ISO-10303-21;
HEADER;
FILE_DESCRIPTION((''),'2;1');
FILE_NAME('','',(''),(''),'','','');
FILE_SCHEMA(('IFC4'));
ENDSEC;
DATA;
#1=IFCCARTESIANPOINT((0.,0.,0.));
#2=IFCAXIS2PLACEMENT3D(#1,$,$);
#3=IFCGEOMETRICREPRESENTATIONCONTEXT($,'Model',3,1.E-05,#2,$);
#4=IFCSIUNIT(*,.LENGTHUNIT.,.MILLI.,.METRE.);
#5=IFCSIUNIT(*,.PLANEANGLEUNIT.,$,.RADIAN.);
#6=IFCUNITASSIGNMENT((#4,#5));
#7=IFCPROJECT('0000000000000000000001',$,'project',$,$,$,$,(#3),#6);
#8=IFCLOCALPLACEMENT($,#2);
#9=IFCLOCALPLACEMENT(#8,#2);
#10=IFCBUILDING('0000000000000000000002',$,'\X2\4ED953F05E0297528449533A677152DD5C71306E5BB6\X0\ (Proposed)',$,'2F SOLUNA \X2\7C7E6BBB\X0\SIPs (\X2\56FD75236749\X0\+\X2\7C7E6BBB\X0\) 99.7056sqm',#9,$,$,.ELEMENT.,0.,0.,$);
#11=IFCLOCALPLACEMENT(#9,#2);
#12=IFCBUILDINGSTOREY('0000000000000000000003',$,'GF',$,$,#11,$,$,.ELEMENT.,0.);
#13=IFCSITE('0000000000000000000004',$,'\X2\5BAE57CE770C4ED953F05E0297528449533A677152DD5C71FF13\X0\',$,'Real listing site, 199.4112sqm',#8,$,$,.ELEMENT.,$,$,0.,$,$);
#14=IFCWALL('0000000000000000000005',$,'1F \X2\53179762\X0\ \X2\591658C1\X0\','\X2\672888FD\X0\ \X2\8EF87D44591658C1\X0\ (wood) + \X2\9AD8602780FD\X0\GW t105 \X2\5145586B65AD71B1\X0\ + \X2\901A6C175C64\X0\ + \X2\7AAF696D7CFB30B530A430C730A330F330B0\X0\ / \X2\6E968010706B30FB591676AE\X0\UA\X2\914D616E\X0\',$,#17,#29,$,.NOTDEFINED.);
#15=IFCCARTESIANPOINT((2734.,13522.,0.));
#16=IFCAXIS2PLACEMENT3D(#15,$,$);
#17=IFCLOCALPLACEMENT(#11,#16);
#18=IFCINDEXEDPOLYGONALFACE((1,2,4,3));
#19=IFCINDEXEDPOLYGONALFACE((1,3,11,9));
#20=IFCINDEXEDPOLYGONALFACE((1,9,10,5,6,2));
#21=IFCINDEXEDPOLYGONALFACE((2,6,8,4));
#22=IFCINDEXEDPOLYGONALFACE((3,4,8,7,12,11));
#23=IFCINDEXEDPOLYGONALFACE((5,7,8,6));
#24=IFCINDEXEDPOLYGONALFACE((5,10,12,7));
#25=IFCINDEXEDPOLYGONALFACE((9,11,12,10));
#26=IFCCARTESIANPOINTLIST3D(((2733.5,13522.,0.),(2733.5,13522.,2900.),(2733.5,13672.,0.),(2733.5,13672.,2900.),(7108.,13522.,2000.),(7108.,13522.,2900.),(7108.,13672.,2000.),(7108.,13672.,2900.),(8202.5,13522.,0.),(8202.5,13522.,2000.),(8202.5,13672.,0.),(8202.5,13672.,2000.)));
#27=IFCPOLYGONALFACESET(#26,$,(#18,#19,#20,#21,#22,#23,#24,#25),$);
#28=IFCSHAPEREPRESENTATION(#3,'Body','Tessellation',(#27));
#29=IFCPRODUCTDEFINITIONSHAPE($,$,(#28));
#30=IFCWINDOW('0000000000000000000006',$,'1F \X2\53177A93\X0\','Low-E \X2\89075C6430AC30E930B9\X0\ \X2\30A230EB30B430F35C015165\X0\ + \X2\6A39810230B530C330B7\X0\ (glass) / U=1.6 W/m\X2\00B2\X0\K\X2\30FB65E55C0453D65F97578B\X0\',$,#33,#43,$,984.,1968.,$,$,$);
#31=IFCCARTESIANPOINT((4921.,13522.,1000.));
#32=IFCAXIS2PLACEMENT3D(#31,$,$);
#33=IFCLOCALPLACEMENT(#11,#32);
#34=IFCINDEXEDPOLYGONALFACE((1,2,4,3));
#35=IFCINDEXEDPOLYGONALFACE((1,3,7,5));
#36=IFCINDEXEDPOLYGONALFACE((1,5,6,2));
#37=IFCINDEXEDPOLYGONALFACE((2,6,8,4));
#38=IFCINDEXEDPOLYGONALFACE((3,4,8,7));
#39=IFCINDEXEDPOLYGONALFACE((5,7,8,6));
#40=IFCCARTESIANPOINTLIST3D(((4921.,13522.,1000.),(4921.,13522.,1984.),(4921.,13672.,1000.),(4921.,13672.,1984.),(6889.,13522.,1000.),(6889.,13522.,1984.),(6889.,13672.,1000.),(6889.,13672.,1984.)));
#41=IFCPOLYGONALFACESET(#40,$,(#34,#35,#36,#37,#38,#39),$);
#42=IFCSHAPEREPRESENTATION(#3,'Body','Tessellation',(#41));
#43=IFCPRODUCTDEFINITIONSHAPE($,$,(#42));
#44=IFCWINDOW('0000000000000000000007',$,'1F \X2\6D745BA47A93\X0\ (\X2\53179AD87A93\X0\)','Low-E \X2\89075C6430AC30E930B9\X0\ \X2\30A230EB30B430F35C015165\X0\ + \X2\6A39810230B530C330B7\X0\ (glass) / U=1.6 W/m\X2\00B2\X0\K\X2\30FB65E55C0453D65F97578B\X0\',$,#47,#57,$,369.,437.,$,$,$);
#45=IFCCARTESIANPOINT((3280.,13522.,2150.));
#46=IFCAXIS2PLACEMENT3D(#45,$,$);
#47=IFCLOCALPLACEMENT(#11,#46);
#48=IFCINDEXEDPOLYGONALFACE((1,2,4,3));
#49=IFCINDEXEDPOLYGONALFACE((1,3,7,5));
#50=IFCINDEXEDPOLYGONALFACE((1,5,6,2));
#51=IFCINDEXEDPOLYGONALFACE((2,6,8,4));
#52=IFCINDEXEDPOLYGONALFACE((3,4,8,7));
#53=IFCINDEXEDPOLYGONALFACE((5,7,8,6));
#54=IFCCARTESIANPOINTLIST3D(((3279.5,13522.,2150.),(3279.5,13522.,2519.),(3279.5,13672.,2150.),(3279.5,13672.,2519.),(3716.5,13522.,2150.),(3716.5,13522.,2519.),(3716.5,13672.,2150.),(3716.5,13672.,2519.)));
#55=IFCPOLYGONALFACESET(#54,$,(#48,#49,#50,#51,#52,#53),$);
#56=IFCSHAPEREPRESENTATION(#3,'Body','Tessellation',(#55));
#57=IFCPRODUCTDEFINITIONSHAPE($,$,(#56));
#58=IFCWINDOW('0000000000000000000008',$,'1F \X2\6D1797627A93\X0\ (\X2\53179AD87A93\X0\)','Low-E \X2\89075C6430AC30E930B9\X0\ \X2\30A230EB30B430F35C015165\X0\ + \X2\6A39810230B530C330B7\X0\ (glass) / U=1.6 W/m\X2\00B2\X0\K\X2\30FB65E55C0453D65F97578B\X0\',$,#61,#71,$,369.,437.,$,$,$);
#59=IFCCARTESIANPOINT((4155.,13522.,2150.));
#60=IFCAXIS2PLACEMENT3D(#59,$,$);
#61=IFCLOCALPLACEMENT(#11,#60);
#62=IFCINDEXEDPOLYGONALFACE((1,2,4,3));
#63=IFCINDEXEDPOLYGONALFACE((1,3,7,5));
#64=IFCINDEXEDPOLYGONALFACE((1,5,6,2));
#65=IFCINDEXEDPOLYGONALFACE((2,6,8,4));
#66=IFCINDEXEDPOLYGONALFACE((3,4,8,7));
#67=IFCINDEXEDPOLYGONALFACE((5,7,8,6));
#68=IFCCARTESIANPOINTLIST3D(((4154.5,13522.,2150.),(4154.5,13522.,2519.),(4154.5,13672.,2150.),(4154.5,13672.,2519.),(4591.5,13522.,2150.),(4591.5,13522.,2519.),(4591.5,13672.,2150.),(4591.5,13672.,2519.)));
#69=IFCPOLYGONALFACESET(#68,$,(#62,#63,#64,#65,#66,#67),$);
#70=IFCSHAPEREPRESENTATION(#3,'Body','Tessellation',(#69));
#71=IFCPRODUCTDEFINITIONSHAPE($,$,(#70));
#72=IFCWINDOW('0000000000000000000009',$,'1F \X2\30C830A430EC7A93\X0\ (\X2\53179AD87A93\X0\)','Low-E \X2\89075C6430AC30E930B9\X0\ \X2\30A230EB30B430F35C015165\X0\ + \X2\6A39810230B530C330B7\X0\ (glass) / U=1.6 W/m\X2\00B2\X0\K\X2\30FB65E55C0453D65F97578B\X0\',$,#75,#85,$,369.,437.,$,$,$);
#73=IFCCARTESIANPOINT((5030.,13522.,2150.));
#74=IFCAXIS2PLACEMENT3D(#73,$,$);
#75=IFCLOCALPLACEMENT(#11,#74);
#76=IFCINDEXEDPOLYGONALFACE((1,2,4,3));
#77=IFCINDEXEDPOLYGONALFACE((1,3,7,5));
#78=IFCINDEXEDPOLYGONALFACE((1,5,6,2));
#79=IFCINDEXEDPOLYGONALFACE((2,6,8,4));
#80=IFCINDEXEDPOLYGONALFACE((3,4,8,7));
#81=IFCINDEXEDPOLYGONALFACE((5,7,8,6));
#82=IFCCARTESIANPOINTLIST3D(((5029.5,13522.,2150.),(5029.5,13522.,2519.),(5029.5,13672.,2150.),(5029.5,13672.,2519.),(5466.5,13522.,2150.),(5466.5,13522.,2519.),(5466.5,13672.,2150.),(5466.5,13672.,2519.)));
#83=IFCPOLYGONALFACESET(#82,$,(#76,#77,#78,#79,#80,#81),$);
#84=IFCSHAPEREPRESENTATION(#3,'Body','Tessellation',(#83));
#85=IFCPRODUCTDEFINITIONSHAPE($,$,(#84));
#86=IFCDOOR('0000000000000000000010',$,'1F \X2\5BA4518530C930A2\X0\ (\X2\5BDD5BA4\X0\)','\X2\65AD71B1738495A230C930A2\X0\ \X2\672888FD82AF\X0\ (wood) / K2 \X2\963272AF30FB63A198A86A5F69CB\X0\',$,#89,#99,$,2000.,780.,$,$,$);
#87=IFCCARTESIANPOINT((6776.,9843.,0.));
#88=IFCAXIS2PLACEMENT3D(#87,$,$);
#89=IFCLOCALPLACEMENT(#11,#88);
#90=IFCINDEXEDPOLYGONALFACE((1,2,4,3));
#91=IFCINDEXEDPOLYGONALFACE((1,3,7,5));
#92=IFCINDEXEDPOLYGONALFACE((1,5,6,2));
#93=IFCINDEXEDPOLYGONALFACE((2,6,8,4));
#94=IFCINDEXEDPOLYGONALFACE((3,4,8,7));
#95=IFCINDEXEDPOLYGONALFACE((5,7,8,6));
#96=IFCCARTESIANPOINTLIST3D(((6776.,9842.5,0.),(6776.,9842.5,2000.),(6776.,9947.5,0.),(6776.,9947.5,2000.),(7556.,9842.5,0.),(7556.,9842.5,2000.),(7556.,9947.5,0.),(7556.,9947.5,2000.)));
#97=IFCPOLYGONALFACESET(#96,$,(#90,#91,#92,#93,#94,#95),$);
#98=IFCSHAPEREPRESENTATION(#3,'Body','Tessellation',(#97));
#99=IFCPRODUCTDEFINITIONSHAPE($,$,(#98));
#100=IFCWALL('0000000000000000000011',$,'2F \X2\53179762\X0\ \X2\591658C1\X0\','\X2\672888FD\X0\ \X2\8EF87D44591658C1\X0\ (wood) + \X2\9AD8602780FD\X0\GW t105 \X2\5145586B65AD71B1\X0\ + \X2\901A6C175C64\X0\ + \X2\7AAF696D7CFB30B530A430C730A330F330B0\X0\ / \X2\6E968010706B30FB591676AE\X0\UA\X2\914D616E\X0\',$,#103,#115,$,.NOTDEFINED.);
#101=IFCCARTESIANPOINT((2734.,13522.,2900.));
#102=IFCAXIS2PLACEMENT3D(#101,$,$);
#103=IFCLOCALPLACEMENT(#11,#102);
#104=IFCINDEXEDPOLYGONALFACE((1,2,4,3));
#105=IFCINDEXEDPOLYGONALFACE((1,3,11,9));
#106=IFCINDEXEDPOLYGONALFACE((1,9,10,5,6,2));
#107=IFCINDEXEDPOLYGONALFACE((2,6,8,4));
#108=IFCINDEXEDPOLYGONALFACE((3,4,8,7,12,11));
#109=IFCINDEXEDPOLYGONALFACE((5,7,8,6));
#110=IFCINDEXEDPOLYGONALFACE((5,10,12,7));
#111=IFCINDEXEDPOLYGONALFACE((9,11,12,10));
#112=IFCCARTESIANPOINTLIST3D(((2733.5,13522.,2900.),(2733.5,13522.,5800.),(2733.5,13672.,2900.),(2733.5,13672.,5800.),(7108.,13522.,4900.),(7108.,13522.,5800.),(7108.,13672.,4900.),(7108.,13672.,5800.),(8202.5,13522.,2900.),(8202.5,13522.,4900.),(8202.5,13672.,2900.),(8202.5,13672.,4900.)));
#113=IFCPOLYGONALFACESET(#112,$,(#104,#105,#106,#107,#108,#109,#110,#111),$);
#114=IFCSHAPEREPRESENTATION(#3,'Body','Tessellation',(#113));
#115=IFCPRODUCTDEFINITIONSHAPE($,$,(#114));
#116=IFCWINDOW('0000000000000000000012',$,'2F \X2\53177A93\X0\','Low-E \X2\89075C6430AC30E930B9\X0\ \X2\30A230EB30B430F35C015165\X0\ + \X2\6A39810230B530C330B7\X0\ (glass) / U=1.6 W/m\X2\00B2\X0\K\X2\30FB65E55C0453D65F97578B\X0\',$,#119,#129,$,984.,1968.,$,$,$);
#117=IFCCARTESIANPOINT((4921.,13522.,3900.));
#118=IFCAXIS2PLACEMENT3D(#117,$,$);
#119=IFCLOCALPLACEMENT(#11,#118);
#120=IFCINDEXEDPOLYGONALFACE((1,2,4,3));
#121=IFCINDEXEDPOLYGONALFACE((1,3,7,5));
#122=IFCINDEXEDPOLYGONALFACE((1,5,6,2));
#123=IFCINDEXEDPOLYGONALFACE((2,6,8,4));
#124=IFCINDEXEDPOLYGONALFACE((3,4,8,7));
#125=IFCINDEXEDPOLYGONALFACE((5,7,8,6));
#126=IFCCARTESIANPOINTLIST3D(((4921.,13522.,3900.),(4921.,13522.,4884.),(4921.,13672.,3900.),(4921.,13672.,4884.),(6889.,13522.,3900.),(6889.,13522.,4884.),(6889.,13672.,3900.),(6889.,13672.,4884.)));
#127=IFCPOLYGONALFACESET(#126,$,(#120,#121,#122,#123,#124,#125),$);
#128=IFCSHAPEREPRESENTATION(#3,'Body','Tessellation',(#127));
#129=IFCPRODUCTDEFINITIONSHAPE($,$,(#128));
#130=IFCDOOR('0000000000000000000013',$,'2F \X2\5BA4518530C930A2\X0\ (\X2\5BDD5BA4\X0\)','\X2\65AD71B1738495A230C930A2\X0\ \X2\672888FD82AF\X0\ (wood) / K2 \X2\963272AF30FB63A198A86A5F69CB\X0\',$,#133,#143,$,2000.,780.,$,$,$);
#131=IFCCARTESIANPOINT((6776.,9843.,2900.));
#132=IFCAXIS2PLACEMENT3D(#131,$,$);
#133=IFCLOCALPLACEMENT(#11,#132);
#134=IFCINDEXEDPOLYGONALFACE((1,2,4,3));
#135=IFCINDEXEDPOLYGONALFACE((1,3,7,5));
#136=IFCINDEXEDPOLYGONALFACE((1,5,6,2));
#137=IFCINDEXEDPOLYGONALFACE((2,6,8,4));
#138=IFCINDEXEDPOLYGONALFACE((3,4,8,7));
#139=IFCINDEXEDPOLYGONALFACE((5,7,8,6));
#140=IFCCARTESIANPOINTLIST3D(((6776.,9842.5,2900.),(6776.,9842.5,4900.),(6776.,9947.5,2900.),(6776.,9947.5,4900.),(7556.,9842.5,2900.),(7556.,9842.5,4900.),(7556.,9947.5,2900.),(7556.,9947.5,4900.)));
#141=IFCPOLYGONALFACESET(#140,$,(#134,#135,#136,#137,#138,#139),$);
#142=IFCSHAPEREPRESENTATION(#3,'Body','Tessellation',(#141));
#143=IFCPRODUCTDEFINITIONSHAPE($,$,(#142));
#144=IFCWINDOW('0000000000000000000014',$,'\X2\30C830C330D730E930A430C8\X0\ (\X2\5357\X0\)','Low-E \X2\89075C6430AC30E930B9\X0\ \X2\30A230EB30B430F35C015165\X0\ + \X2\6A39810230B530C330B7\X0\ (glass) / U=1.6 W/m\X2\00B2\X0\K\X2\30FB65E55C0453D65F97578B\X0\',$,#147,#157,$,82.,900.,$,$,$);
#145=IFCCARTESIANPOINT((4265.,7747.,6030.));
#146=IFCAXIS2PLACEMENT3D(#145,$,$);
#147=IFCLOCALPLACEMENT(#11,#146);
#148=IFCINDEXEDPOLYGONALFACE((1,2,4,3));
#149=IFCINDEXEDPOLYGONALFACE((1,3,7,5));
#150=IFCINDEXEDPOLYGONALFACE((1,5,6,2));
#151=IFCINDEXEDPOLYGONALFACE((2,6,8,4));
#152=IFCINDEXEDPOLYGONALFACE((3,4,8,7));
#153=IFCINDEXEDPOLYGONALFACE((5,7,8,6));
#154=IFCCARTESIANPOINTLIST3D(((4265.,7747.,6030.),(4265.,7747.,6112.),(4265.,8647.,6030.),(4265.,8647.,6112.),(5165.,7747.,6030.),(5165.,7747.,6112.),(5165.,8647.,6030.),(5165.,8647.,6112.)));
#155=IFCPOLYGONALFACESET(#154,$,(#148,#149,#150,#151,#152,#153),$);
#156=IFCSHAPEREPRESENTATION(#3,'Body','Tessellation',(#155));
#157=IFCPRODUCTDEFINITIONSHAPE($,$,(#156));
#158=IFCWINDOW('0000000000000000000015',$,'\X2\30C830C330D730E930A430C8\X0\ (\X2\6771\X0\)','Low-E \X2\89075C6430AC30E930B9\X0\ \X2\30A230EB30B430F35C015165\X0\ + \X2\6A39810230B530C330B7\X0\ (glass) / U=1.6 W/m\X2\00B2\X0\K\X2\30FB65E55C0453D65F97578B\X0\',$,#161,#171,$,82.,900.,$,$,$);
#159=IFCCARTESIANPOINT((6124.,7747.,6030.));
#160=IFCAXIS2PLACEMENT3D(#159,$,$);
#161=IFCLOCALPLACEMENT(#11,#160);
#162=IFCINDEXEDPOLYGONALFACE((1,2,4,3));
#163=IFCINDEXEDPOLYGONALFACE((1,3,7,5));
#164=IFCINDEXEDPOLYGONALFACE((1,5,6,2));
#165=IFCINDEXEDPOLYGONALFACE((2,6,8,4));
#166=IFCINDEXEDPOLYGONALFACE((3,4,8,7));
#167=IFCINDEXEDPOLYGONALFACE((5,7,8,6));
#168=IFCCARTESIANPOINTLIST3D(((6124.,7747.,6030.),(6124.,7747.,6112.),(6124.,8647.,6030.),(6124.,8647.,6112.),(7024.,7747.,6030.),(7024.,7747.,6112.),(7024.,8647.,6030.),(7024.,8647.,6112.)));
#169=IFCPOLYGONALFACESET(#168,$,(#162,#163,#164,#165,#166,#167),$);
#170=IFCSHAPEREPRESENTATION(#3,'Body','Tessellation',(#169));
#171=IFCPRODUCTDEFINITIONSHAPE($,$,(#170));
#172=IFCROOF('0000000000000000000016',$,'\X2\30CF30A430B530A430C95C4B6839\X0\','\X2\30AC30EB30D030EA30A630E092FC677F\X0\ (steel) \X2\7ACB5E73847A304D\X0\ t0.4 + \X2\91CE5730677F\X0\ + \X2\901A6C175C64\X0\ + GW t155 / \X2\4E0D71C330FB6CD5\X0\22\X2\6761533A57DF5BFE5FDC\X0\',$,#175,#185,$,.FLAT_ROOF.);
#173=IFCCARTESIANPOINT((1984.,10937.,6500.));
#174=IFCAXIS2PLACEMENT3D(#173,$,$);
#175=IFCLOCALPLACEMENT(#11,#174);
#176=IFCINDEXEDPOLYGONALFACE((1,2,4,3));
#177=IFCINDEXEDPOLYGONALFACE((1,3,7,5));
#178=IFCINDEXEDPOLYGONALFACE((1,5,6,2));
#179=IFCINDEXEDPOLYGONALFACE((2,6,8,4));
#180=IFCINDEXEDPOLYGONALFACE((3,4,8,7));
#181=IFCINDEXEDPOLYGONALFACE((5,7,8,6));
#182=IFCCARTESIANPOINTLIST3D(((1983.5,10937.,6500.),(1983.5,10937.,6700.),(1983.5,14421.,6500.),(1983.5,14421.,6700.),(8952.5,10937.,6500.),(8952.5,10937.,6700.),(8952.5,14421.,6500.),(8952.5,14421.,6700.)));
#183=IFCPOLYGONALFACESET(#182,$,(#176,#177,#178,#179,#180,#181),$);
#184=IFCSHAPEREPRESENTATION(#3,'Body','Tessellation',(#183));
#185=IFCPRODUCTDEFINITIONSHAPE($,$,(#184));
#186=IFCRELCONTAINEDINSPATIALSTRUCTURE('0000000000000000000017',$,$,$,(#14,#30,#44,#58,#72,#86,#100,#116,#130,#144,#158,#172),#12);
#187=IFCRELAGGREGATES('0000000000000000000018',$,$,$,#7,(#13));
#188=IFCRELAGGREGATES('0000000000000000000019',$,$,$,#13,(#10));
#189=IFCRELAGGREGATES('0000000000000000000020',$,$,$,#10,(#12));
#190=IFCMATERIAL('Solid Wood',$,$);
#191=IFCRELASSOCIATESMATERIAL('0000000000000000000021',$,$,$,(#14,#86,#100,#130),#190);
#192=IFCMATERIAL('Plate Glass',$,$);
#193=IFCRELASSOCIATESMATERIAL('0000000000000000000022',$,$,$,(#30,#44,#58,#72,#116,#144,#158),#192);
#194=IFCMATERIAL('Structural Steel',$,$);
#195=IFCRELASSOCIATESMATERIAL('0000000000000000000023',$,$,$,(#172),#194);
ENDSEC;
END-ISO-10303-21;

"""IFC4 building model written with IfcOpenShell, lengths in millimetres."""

from ifc_helpers import new_model, si_unit, frame, frame_2d, origin, place, context, project, spatial, rectangle, extrude, material, element, fill, save


model = new_model("IFC4")

# Units and contexts
model_context = context("Model", 3, precision=1e-05, world=origin())
ifc_project = project(units=[si_unit("LENGTHUNIT", "METRE", prefix="MILLI"), si_unit("PLANEANGLEUNIT", "RADIAN")], contexts=[model_context])

# Site, building, storey
site_placement = place(None, origin())
site = spatial("IfcSite", under=ifc_project, at=site_placement, Name="宮城県仙台市青葉区東勝山３", ObjectType="Real listing site, 199.4112sqm", CompositionType="ELEMENT", RefElevation=0.0)
building_placement = place(site_placement, origin())
building = spatial("IfcBuilding", under=site, at=building_placement, Name="仙台市青葉区東勝山の家 (Proposed)", ObjectType="2F SOLUNA 籾殻SIPs (国産杉+籾殻) 99.7056sqm", CompositionType="ELEMENT", ElevationOfRefHeight=0.0, ElevationOfTerrain=0.0)
storey_placement = place(building_placement, origin())
storey = spatial("IfcBuildingStorey", under=building, at=storey_placement, Name="GF", CompositionType="ELEMENT", Elevation=0.0)

# Wall, openings, windows
ifc_material_1 = material(Name="Solid Wood")
wall_1_placement = place(storey_placement, frame((2734.0, 13522.0, 0.0)))
wall_1 = element("IfcWall", 1, at=wall_1_placement, inside=storey, material=ifc_material_1, Name="1F 北面 外壁", Description="木製 軸組外壁 (wood) + 高性能GW t105 充填断熱 + 通気層 + 窯業系サイディング / 準耐火・外皮UA配慮", PredefinedType="NOTDEFINED", context=model_context, shape_type="SweptSolid", body=[
    extrude(rectangle(XDim=5469.0, YDim=150.0, at=frame_2d((2734.0, 75.0))), frame((2734.0, 13522.0, 0.0)), (0.0, 0.0, 1.0), 2900.0),
])
opening_1_placement = place(storey_placement, frame((4921.0, 13522.0, 1000.0)))
opening_1 = element("IfcOpeningElement", 2, at=opening_1_placement, cuts=wall_1, PredefinedType="NOTDEFINED", context=model_context, shape_type="SweptSolid", body=[
    extrude(rectangle(XDim=1968.0, YDim=150.0, at=frame_2d((984.0, 75.0))), frame((4921.0, 13522.0, 1000.0)), (0.0, 0.0, 1.0), 984.0),
])
opening_2_placement = place(storey_placement, frame((3280.0, 13522.0, 2150.0)))
opening_2 = element("IfcOpeningElement", 3, at=opening_2_placement, cuts=wall_1, PredefinedType="NOTDEFINED", context=model_context, shape_type="SweptSolid", body=[
    extrude(rectangle(XDim=437.0, YDim=150.0, at=frame_2d((218.0, 75.0))), frame((3280.0, 13522.0, 2150.0)), (0.0, 0.0, 1.0), 369.0),
])
opening_3_placement = place(storey_placement, frame((4155.0, 13522.0, 2150.0)))
opening_3 = element("IfcOpeningElement", 4, at=opening_3_placement, cuts=wall_1, PredefinedType="NOTDEFINED", context=model_context, shape_type="SweptSolid", body=[
    extrude(rectangle(XDim=437.0, YDim=150.0, at=frame_2d((218.0, 75.0))), frame((4155.0, 13522.0, 2150.0)), (0.0, 0.0, 1.0), 369.0),
])
opening_4_placement = place(storey_placement, frame((5030.0, 13522.0, 2150.0)))
opening_4 = element("IfcOpeningElement", 5, at=opening_4_placement, cuts=wall_1, PredefinedType="NOTDEFINED", context=model_context, shape_type="SweptSolid", body=[
    extrude(rectangle(XDim=437.0, YDim=150.0, at=frame_2d((218.0, 75.0))), frame((5030.0, 13522.0, 2150.0)), (0.0, 0.0, 1.0), 369.0),
])
ifc_material_2 = material(Name="Plate Glass")
window_1_placement = place(storey_placement, frame((4921.0, 13522.0, 1000.0)))
window_1 = element("IfcWindow", 6, at=window_1_placement, inside=storey, material=ifc_material_2, Name="1F 北窓", Description="Low-E 複層ガラス アルゴン封入 + 樹脂サッシ (glass) / U=1.6 W/m²K・日射取得型", OverallHeight=984.0, OverallWidth=1968.0, context=model_context, shape_type="SweptSolid", body=[
    extrude(rectangle(XDim=1968.0, YDim=150.0, at=frame_2d((984.0, 75.0))), frame((4921.0, 13522.0, 1000.0)), (0.0, 0.0, 1.0), 984.0),
])
fill(opening_1, window_1)
window_2_placement = place(storey_placement, frame((3280.0, 13522.0, 2150.0)))
window_2 = element("IfcWindow", 7, at=window_2_placement, inside=storey, material=ifc_material_2, Name="1F 浴室窓 (北高窓)", Description="Low-E 複層ガラス アルゴン封入 + 樹脂サッシ (glass) / U=1.6 W/m²K・日射取得型", OverallHeight=369.0, OverallWidth=437.0, context=model_context, shape_type="SweptSolid", body=[
    extrude(rectangle(XDim=437.0, YDim=150.0, at=frame_2d((218.0, 75.0))), frame((3280.0, 13522.0, 2150.0)), (0.0, 0.0, 1.0), 369.0),
])
fill(opening_2, window_2)
window_3_placement = place(storey_placement, frame((4155.0, 13522.0, 2150.0)))
window_3 = element("IfcWindow", 8, at=window_3_placement, inside=storey, material=ifc_material_2, Name="1F 洗面窓 (北高窓)", Description="Low-E 複層ガラス アルゴン封入 + 樹脂サッシ (glass) / U=1.6 W/m²K・日射取得型", OverallHeight=369.0, OverallWidth=437.0, context=model_context, shape_type="SweptSolid", body=[
    extrude(rectangle(XDim=437.0, YDim=150.0, at=frame_2d((218.0, 75.0))), frame((4155.0, 13522.0, 2150.0)), (0.0, 0.0, 1.0), 369.0),
])
fill(opening_3, window_3)
window_4_placement = place(storey_placement, frame((5030.0, 13522.0, 2150.0)))
window_4 = element("IfcWindow", 9, at=window_4_placement, inside=storey, material=ifc_material_2, Name="1F トイレ窓 (北高窓)", Description="Low-E 複層ガラス アルゴン封入 + 樹脂サッシ (glass) / U=1.6 W/m²K・日射取得型", OverallHeight=369.0, OverallWidth=437.0, context=model_context, shape_type="SweptSolid", body=[
    extrude(rectangle(XDim=437.0, YDim=150.0, at=frame_2d((218.0, 75.0))), frame((5030.0, 13522.0, 2150.0)), (0.0, 0.0, 1.0), 369.0),
])
fill(opening_4, window_4)

# Door
door_1_placement = place(storey_placement, frame((6776.0, 9843.0, 0.0)))
element("IfcDoor", 10, at=door_1_placement, inside=storey, material=ifc_material_1, Name="1F 室内ドア (寝室)", Description="断熱玄関ドア 木製芯 (wood) / K2 防犯・採風機構", OverallHeight=2000.0, OverallWidth=780.0, context=model_context, shape_type="SweptSolid", body=[
    extrude(rectangle(XDim=780.0, YDim=105.0, at=frame_2d((390.0, 52.0))), frame((6776.0, 9843.0, 0.0)), (0.0, 0.0, 1.0), 2000.0),
])

# Wall, opening, window
wall_2_placement = place(storey_placement, frame((2734.0, 13522.0, 2900.0)))
wall_2 = element("IfcWall", 11, at=wall_2_placement, inside=storey, material=ifc_material_1, Name="2F 北面 外壁", Description="木製 軸組外壁 (wood) + 高性能GW t105 充填断熱 + 通気層 + 窯業系サイディング / 準耐火・外皮UA配慮", PredefinedType="NOTDEFINED", context=model_context, shape_type="SweptSolid", body=[
    extrude(rectangle(XDim=5469.0, YDim=150.0, at=frame_2d((2734.0, 75.0))), frame((2734.0, 13522.0, 2900.0)), (0.0, 0.0, 1.0), 2900.0),
])
opening_5_placement = place(storey_placement, frame((4921.0, 13522.0, 3900.0)))
opening_5 = element("IfcOpeningElement", 12, at=opening_5_placement, cuts=wall_2, PredefinedType="NOTDEFINED", context=model_context, shape_type="SweptSolid", body=[
    extrude(rectangle(XDim=1968.0, YDim=150.0, at=frame_2d((984.0, 75.0))), frame((4921.0, 13522.0, 3900.0)), (0.0, 0.0, 1.0), 984.0),
])
window_5_placement = place(storey_placement, frame((4921.0, 13522.0, 3900.0)))
window_5 = element("IfcWindow", 13, at=window_5_placement, inside=storey, material=ifc_material_2, Name="2F 北窓", Description="Low-E 複層ガラス アルゴン封入 + 樹脂サッシ (glass) / U=1.6 W/m²K・日射取得型", OverallHeight=984.0, OverallWidth=1968.0, context=model_context, shape_type="SweptSolid", body=[
    extrude(rectangle(XDim=1968.0, YDim=150.0, at=frame_2d((984.0, 75.0))), frame((4921.0, 13522.0, 3900.0)), (0.0, 0.0, 1.0), 984.0),
])
fill(opening_5, window_5)

# Door
door_2_placement = place(storey_placement, frame((6776.0, 9843.0, 2900.0)))
element("IfcDoor", 14, at=door_2_placement, inside=storey, material=ifc_material_1, Name="2F 室内ドア (寝室)", Description="断熱玄関ドア 木製芯 (wood) / K2 防犯・採風機構", OverallHeight=2000.0, OverallWidth=780.0, context=model_context, shape_type="SweptSolid", body=[
    extrude(rectangle(XDim=780.0, YDim=105.0, at=frame_2d((390.0, 52.0))), frame((6776.0, 9843.0, 2900.0)), (0.0, 0.0, 1.0), 2000.0),
])

# Windows
window_6_placement = place(storey_placement, frame((4265.0, 7747.0, 6030.0)))
element("IfcWindow", 15, at=window_6_placement, inside=storey, material=ifc_material_2, Name="トップライト (南)", Description="Low-E 複層ガラス アルゴン封入 + 樹脂サッシ (glass) / U=1.6 W/m²K・日射取得型", OverallHeight=82.0, OverallWidth=900.0, context=model_context, shape_type="SweptSolid", body=[
    extrude(rectangle(XDim=900.0, YDim=900.0, at=frame_2d((450.0, 450.0))), frame((4265.0, 7747.0, 6030.0)), (0.0, 0.0, 1.0), 82.0),
])
window_7_placement = place(storey_placement, frame((6124.0, 7747.0, 6030.0)))
element("IfcWindow", 16, at=window_7_placement, inside=storey, material=ifc_material_2, Name="トップライト (東)", Description="Low-E 複層ガラス アルゴン封入 + 樹脂サッシ (glass) / U=1.6 W/m²K・日射取得型", OverallHeight=82.0, OverallWidth=900.0, context=model_context, shape_type="SweptSolid", body=[
    extrude(rectangle(XDim=900.0, YDim=900.0, at=frame_2d((450.0, 450.0))), frame((6124.0, 7747.0, 6030.0)), (0.0, 0.0, 1.0), 82.0),
])

# Roof
ifc_material_3 = material(Name="Structural Steel")
roof_placement = place(storey_placement, frame((1984.0, 10937.0, 6500.0)))
element("IfcRoof", 17, at=roof_placement, inside=storey, material=ifc_material_3, Name="ハイサイド屋根", Description="ガルバリウム鋼板 (steel) 立平葺き t0.4 + 野地板 + 通気層 + GW t155 / 不燃・法22条区域対応", PredefinedType="FLAT_ROOF", context=model_context, shape_type="SweptSolid", body=[
    extrude(rectangle(XDim=6969.0, YDim=3484.0, at=frame_2d((3484.0, 1742.0))), frame((1984.0, 10937.0, 6500.0)), (0.0, 0.0, 1.0), 200.0),
])

save(model, "model.ifc")
